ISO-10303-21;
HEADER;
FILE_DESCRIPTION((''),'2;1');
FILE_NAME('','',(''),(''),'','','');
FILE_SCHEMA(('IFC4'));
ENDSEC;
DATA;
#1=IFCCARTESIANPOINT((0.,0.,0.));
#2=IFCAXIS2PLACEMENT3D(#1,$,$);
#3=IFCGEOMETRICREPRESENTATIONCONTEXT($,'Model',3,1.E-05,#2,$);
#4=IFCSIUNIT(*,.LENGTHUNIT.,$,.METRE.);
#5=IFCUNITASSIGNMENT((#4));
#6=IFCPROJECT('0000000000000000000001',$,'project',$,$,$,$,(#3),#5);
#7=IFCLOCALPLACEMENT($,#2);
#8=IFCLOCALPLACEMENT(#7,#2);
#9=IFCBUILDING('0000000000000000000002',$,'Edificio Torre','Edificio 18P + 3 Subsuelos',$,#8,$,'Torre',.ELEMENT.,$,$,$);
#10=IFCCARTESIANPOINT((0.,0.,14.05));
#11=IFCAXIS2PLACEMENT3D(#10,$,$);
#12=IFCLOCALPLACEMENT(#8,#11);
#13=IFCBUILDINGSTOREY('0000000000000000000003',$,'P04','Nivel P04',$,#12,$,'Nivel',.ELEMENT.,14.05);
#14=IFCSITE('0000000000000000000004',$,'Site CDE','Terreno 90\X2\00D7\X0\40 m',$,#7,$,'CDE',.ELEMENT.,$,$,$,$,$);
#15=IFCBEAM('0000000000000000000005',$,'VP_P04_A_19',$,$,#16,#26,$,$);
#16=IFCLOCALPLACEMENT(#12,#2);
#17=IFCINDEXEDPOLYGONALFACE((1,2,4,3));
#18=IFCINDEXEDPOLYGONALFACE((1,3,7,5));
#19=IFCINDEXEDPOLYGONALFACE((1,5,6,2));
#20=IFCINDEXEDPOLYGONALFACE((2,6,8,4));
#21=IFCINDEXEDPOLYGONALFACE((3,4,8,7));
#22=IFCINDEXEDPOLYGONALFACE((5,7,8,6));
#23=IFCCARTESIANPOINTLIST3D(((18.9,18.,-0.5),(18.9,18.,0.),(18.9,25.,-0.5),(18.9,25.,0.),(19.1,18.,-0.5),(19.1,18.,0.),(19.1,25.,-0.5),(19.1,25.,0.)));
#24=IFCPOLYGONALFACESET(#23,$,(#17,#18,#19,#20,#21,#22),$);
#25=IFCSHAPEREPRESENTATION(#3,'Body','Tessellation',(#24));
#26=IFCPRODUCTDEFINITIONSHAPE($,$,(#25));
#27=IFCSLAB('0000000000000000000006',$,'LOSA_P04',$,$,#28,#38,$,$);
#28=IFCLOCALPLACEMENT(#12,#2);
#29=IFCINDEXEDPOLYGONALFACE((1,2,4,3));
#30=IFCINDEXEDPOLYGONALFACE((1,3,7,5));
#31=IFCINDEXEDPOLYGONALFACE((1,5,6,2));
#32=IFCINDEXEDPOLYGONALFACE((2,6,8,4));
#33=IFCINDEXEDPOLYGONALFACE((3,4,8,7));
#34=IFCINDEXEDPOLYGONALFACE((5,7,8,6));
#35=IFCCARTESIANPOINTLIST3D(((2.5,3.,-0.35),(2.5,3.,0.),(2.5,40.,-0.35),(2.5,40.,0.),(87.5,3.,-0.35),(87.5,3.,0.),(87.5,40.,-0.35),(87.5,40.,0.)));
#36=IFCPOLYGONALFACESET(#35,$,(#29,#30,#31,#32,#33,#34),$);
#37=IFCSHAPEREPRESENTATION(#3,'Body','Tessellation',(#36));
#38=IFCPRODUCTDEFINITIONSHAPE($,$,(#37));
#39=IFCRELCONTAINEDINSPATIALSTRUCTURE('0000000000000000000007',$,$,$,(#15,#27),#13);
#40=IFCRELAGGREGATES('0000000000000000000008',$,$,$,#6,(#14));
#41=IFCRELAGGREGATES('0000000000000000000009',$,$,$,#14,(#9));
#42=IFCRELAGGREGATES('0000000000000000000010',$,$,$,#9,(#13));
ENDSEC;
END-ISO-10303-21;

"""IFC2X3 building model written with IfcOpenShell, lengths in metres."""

from ifc_helpers import new_model, si_unit, frame, origin, origin_2d, place, context, project, spatial, rectangle, extrude, element, save


model = new_model("IFC2X3")

# Units and contexts
model_context = context("Model", 3, precision=1e-05, world=origin())
ifc_project = project(units=[si_unit("LENGTHUNIT", "METRE")], contexts=[model_context])

# Site, building, storey
site_placement = place(None, origin())
site = spatial("IfcSite", under=ifc_project, at=site_placement, Name="Site CDE", Description="Terreno 90×40 m", LongName="CDE", CompositionType="ELEMENT")
building_placement = place(site_placement, origin())
building = spatial("IfcBuilding", under=site, at=building_placement, Name="Edificio Torre", Description="Edificio 18P + 3 Subsuelos", LongName="Torre", CompositionType="ELEMENT")
storey_placement = place(building_placement, frame((0.0, 0.0, 14.05)))
storey = spatial("IfcBuildingStorey", under=building, at=storey_placement, Name="P04", Description="Nivel P04", LongName="Nivel", CompositionType="ELEMENT", Elevation=14.05)

# Beam
beam_1_placement = place(storey_placement, frame((19.0, 21.5, -0.5)))
element("IfcBeam", 1, at=beam_1_placement, inside=storey, Name="VP_P04_A_19", context=model_context, shape_type="SweptSolid", body=[
    extrude(rectangle(XDim=0.2, YDim=7.0, at=origin_2d()), origin(), (0.0, 0.0, 1.0), 0.5),
])

# Slab
slab_placement = place(storey_placement, frame((45.0, 21.5, -0.35)))
element("IfcSlab", 2, at=slab_placement, inside=storey, Name="LOSA_P04", context=model_context, shape_type="SweptSolid", body=[
    extrude(rectangle(XDim=85.0, YDim=37.0, at=origin_2d()), origin(), (0.0, 0.0, 1.0), 0.35),
])

save(model, "model.ifc")
